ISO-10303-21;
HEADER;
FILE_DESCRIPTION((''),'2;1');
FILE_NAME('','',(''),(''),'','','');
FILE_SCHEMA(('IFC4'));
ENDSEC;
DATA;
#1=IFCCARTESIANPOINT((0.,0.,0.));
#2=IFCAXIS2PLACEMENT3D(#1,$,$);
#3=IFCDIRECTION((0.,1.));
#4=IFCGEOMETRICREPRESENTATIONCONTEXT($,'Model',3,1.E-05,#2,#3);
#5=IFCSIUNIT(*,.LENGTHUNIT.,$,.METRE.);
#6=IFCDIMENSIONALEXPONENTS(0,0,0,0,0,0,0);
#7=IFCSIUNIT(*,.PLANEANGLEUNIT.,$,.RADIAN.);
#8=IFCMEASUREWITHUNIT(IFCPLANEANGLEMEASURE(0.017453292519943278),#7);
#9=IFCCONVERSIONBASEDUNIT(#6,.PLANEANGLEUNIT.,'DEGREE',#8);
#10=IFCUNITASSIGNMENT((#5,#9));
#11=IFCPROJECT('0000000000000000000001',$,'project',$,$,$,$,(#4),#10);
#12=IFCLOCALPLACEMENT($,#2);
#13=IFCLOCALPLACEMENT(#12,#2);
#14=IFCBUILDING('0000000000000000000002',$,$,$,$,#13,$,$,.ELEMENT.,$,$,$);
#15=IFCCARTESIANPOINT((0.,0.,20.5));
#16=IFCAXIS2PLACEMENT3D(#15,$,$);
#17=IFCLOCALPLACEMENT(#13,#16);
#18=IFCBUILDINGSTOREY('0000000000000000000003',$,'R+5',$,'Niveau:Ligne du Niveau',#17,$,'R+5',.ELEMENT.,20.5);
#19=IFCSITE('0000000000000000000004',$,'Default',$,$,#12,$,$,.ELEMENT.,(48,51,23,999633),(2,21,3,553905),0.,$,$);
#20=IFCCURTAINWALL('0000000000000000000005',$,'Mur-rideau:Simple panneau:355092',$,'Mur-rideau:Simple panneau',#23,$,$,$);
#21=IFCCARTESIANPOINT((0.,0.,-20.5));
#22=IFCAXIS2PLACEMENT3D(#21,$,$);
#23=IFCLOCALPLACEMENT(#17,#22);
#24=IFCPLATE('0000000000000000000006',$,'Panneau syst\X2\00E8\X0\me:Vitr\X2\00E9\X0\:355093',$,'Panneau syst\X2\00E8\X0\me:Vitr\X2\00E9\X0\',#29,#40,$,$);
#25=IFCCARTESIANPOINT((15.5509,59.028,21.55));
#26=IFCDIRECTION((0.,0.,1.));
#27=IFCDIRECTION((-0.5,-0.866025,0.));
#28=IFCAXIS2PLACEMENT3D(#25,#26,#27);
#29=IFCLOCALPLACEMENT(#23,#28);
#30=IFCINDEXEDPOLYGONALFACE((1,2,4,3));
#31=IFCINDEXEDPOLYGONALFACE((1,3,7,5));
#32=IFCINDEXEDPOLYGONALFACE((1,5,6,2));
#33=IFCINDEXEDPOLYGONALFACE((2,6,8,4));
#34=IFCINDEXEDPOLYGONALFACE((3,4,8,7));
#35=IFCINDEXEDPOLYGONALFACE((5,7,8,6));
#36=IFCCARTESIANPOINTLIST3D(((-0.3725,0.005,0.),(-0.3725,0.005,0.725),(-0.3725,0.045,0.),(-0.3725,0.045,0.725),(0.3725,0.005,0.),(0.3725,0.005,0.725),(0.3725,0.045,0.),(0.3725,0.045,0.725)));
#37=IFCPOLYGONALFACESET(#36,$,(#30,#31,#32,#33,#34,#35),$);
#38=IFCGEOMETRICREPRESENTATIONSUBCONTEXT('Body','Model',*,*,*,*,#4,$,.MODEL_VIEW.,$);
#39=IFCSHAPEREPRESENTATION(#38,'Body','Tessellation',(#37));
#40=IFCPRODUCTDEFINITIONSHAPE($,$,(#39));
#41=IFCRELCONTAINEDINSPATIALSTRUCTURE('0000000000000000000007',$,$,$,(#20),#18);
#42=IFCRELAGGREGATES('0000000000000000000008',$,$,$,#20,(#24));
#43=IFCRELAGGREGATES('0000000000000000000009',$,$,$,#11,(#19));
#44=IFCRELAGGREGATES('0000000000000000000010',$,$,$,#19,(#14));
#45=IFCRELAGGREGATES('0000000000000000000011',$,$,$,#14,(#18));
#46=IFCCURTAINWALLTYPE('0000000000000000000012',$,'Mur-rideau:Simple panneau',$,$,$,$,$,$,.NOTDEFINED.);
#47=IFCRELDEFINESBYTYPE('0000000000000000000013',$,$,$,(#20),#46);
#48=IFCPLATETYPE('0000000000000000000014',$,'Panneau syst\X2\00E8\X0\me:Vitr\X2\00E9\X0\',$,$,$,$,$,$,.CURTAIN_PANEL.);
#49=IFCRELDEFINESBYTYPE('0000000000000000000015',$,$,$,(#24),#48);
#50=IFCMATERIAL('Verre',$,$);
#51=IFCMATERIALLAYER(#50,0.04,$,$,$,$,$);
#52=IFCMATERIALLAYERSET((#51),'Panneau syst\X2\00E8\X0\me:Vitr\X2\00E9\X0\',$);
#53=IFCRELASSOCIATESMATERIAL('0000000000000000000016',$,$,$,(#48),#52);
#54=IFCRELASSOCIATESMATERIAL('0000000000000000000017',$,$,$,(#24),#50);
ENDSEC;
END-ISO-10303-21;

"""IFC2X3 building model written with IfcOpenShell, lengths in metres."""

from ifc_helpers import new_model, entity, si_unit, converted_unit, direction, frame, frame_2d, origin, place, context, subcontext, project, spatial, rectangle, extrude, source, transform, mapped, material, layer, layer_set, type_object, type_shapes, element, aggregate, save


model = new_model("IFC2X3")

# Units and contexts
model_context = context("Model", 3, precision=1e-05, world=origin(), true_north=direction((0.0, 1.0)))
body_context = subcontext(model_context, "Body", "Model", "MODEL_VIEW")
ifc_project = project(units=[si_unit("LENGTHUNIT", "METRE"), converted_unit("PLANEANGLEUNIT", "DEGREE", entity("IfcPlaneAngleMeasure", 0.017453292519943278), si_unit("PLANEANGLEUNIT", "RADIAN"), dimensions=[0, 0, 0, 0, 0, 0, 0])], contexts=[model_context])

# Site, building, storey
site_placement = place(None, origin())
site = spatial("IfcSite", under=ifc_project, at=site_placement, Name="Default", CompositionType="ELEMENT", RefLatitude=(48, 51, 23, 999633), RefLongitude=(2, 21, 3, 553905), RefElevation=0.0)
building_placement = place(site_placement, origin())
building = spatial("IfcBuilding", under=site, at=building_placement, CompositionType="ELEMENT")
storey_placement = place(building_placement, frame((0.0, 0.0, 20.5)))
storey = spatial("IfcBuildingStorey", under=building, at=storey_placement, Name="R+5", ObjectType="Niveau:Ligne du Niveau", LongName="R+5", CompositionType="ELEMENT", Elevation=20.5)

# Curtain wall
curtain_wall_type = type_object("IfcCurtainWallType", Name="Mur-rideau:Simple panneau", PredefinedType="NOTDEFINED")
curtain_wall_1_placement = place(storey_placement, frame((0.0, 0.0, -20.5)))
curtain_wall_1 = element("IfcCurtainWall", 1, at=curtain_wall_1_placement, inside=storey, type_object=curtain_wall_type, Name="Mur-rideau:Simple panneau:355092", ObjectType="Mur-rideau:Simple panneau")

# Plate
ifc_material_1 = material(Name="Verre")
ifc_layer_1 = layer(ifc_material_1, 0.04)
ifc_layer_set_1 = layer_set([ifc_layer_1], Name="Panneau système:Vitré")
plate_type_1 = type_object("IfcPlateType", Name="Panneau système:Vitré", PredefinedType="CURTAIN_PANEL", material=ifc_layer_set_1)
shared_shape_1 = source(origin(), body_context, "Body", "SweptSolid", [
    extrude(rectangle(XDim=0.04, YDim=0.745, at=frame_2d((0.0, 0.0), x_axis=(1.0, 0.0))), frame((0.0, 0.025, 0.0), z_axis=(0.0, 0.0, 1.0), x_axis=(0.0, 1.0, 0.0)), (0.0, 0.0, 1.0), 0.725),
])
type_shapes(plate_type_1, [shared_shape_1])
plate_1_placement = place(curtain_wall_1_placement, frame((15.5509, 59.028, 21.55), z_axis=(0.0, 0.0, 1.0), x_axis=(-0.5, -0.866025, 0.0)))
plate_1 = element("IfcPlate", 2, at=plate_1_placement, type_object=plate_type_1, material=ifc_material_1, Name="Panneau système:Vitré:355093", ObjectType="Panneau système:Vitré", context=body_context, shape_type="MappedRepresentation", body=[
    mapped(shared_shape_1, transform((0.0, 0.0, 0.0), scale=1.0)),
])
aggregate(curtain_wall_1, [plate_1])

save(model, "model.ifc")
